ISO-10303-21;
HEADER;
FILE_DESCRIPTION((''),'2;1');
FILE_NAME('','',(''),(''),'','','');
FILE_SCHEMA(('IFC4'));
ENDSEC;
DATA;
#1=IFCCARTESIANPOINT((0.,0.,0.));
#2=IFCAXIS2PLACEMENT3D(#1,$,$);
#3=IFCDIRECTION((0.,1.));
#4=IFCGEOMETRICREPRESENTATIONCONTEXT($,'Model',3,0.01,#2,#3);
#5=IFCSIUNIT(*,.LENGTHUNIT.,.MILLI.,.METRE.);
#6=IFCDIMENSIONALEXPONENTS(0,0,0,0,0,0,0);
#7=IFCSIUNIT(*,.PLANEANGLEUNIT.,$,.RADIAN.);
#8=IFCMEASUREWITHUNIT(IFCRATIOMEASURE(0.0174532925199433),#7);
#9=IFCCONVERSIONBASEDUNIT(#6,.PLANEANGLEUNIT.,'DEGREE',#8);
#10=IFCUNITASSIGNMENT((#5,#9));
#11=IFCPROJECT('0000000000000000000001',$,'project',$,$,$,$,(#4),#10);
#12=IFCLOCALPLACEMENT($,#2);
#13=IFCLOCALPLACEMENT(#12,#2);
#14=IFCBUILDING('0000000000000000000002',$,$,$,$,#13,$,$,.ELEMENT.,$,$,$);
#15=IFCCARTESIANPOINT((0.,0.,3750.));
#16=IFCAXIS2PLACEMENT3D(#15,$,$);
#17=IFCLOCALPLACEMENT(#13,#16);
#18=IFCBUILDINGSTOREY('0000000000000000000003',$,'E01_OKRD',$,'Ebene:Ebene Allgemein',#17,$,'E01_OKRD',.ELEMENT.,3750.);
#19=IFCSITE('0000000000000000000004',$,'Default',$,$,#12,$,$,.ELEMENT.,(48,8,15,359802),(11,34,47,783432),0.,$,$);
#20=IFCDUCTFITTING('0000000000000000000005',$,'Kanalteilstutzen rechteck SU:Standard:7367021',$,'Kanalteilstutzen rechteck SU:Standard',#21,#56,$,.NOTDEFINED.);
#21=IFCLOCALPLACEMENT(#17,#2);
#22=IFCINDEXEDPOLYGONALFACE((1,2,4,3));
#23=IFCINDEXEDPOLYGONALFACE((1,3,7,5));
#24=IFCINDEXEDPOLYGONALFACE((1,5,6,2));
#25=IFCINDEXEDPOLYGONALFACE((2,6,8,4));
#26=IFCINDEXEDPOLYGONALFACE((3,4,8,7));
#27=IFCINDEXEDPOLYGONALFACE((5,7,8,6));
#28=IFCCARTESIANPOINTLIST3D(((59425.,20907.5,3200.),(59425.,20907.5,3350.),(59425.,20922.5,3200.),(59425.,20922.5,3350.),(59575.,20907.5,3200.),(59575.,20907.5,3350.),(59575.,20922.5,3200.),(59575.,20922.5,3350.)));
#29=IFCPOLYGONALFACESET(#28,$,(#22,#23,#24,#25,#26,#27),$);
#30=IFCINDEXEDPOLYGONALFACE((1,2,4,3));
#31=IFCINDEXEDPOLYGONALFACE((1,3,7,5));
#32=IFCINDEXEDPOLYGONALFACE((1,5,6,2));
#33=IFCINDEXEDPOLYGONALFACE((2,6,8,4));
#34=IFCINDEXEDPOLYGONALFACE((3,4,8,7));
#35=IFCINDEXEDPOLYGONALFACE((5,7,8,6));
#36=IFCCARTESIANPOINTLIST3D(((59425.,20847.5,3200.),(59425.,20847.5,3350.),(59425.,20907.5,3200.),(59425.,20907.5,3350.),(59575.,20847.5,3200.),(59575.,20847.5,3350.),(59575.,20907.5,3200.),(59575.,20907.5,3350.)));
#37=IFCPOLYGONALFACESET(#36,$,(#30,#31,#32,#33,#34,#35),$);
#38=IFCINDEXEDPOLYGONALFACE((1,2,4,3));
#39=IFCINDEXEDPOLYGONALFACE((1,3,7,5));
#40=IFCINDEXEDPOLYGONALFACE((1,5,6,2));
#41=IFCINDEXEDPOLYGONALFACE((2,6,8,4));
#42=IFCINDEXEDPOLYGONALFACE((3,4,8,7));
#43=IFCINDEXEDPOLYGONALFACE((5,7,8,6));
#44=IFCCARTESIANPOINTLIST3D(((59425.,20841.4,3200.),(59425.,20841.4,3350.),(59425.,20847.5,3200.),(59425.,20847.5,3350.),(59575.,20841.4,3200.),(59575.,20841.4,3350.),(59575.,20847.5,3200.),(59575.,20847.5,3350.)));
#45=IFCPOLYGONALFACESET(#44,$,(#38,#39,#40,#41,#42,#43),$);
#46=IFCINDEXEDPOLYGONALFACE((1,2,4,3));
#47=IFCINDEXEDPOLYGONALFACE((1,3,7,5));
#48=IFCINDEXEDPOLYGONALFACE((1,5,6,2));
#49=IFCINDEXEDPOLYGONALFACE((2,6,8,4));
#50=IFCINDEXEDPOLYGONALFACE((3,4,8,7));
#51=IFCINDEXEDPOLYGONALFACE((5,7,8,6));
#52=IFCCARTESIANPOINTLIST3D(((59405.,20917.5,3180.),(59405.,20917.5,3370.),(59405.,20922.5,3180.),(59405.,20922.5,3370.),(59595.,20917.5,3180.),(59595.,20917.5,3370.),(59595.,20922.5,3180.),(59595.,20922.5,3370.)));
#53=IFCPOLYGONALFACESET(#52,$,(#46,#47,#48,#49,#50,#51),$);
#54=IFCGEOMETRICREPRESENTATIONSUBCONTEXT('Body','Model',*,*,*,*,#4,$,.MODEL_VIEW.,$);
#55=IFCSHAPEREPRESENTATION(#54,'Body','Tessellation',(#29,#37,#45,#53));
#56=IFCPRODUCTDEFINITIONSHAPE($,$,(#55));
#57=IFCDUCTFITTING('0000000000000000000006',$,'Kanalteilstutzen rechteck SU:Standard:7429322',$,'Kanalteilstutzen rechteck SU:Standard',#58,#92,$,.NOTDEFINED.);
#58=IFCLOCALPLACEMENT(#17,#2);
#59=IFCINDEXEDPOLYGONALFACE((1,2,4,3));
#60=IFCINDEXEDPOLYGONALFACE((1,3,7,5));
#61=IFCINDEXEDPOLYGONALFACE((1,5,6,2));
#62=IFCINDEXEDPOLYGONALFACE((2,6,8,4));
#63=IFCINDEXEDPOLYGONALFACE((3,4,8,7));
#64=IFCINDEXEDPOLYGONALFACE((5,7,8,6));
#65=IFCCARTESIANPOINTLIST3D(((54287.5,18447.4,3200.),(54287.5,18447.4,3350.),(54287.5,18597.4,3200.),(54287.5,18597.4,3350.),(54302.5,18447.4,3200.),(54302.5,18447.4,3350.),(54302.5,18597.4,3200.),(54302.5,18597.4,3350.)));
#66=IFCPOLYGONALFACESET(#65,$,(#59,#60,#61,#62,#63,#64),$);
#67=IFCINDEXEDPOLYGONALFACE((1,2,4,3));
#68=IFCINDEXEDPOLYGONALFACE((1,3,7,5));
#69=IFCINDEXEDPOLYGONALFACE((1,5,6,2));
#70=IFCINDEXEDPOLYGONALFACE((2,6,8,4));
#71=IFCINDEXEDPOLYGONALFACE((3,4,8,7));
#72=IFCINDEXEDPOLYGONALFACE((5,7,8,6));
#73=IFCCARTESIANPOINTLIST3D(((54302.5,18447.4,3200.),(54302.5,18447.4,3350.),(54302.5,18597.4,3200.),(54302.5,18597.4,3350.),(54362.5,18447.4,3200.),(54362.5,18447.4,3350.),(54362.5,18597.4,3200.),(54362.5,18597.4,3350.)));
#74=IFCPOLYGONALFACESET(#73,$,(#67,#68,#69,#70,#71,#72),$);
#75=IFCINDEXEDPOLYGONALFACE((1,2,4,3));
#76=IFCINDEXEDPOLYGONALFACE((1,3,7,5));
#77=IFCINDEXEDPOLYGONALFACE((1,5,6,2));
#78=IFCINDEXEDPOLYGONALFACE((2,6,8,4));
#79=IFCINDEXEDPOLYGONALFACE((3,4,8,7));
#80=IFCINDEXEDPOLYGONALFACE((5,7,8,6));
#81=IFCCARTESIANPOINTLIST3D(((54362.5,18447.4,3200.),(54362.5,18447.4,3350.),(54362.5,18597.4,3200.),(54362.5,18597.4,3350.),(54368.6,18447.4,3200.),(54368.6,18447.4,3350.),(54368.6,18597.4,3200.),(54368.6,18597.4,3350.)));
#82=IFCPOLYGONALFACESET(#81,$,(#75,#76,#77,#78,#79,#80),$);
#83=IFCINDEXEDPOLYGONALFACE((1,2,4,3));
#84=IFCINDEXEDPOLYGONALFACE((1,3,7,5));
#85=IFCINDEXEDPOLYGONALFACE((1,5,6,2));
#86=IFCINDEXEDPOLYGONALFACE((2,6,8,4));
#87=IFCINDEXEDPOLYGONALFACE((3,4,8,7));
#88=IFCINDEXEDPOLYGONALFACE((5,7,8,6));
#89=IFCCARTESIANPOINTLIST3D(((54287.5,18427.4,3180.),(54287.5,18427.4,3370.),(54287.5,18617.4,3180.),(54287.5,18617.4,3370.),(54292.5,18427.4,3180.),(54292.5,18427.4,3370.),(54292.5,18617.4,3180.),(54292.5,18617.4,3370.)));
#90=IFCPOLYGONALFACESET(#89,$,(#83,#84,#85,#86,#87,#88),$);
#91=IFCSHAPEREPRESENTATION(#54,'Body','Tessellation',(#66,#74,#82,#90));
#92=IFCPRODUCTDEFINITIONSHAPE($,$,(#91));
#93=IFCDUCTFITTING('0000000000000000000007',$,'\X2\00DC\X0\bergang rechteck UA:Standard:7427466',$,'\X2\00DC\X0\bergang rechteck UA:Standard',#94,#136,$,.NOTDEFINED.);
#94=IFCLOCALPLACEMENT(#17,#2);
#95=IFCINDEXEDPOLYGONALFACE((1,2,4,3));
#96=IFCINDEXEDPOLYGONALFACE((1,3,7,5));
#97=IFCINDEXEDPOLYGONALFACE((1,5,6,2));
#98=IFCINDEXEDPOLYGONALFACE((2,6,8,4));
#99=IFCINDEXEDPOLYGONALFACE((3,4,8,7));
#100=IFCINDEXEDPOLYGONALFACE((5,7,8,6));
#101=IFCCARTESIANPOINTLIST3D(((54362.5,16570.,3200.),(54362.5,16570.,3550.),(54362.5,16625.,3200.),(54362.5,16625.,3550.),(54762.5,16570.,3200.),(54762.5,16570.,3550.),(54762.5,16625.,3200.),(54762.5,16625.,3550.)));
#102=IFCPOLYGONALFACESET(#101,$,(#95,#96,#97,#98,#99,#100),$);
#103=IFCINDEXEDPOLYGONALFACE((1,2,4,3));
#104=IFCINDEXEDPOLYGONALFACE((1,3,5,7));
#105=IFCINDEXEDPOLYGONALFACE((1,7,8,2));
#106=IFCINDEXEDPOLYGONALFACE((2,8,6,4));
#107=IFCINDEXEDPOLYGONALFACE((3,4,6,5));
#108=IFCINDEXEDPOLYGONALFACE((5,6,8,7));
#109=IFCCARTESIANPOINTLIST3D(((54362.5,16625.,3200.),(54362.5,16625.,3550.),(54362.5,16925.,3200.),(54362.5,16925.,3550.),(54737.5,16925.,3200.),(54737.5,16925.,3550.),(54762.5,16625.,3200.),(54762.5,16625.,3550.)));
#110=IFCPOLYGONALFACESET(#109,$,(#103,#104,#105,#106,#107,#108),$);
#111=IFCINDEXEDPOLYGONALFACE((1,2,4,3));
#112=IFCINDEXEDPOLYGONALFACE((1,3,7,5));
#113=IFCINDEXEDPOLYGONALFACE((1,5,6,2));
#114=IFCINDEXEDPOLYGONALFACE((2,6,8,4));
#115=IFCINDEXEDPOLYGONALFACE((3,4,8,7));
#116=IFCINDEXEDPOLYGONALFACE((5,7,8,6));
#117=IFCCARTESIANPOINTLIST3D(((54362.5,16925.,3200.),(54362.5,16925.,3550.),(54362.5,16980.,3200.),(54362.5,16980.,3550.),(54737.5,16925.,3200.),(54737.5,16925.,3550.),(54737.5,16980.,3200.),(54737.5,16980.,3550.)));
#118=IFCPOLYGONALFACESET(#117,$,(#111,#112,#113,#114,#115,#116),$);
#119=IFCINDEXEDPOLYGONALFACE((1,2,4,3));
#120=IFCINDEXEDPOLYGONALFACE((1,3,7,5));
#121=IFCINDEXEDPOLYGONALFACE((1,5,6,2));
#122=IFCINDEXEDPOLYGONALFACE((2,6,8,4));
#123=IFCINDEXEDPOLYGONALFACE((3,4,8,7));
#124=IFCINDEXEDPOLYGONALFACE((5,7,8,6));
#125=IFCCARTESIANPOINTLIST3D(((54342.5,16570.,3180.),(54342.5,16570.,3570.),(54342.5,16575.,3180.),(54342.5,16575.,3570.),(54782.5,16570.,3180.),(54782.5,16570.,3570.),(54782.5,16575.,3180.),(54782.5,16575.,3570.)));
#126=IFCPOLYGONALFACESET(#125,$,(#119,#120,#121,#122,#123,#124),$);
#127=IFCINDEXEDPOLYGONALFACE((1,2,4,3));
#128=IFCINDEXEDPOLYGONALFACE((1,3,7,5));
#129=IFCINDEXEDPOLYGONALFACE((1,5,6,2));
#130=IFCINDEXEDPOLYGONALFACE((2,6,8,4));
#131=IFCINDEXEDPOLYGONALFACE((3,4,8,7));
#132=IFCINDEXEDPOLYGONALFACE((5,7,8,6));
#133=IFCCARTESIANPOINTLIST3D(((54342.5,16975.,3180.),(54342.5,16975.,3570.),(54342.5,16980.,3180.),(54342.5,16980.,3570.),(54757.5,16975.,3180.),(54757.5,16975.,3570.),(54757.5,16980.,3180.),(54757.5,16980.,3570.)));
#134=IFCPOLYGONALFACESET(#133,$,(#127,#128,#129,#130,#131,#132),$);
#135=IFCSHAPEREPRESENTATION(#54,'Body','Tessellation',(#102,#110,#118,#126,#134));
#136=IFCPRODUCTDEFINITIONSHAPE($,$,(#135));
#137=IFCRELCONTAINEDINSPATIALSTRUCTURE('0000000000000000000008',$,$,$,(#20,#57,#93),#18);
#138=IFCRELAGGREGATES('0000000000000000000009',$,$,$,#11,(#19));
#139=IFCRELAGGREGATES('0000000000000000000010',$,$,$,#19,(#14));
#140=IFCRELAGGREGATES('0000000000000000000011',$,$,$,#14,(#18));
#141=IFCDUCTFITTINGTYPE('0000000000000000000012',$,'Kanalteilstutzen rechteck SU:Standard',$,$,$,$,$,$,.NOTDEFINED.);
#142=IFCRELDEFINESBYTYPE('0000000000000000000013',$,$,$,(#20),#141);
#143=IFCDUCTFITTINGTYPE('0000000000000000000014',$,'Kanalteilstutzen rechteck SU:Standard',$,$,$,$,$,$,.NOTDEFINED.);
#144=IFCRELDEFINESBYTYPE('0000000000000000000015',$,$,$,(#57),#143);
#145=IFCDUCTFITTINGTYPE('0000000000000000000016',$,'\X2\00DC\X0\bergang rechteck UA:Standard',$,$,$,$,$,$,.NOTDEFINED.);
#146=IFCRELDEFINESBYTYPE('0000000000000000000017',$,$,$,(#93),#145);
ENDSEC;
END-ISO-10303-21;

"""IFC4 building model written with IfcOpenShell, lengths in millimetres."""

from ifc_helpers import new_model, entity, si_unit, converted_unit, direction, frame, frame_2d, origin, origin_2d_with_axis, place, context, subcontext, project, spatial, polyline, rectangle, outline, extrude, source, transform, mapped, type_object, type_shapes, element, save


model = new_model("IFC4")

# Units and contexts
model_context = context("Model", 3, precision=0.01, world=origin(), true_north=direction((0.0, 1.0)))
body_context = subcontext(model_context, "Body", "Model", "MODEL_VIEW")
ifc_project = project(units=[si_unit("LENGTHUNIT", "METRE", prefix="MILLI"), converted_unit("PLANEANGLEUNIT", "DEGREE", entity("IfcRatioMeasure", 0.0174532925199433), si_unit("PLANEANGLEUNIT", "RADIAN"), dimensions=[0, 0, 0, 0, 0, 0, 0])], contexts=[model_context])

# Site, building, storey
site_placement = place(None, origin())
site = spatial("IfcSite", under=ifc_project, at=site_placement, Name="Default", CompositionType="ELEMENT", RefLatitude=(48, 8, 15, 359802), RefLongitude=(11, 34, 47, 783432), RefElevation=0.0)
building_placement = place(site_placement, origin())
building = spatial("IfcBuilding", under=site, at=building_placement, CompositionType="ELEMENT")
storey_placement = place(building_placement, frame((0.0, 0.0, 3750.0)))
storey = spatial("IfcBuildingStorey", under=building, at=storey_placement, Name="E01_OKRD", ObjectType="Ebene:Ebene Allgemein", LongName="E01_OKRD", CompositionType="ELEMENT", Elevation=3750.0)

# Duct fittings
duct_fitting_type_1 = type_object("IfcDuctFittingType", Name="Kanalteilstutzen rechteck SU:Standard", PredefinedType="NOTDEFINED")
shared_shape_1 = source(origin(), body_context, "Body", "SweptSolid", [
    extrude(rectangle(XDim=150.0, YDim=15.0, at=origin_2d_with_axis()), frame((67.5, 0.0, -75.0), z_axis=(0.0, 0.0, 1.0), x_axis=(0.0, -1.0, 0.0)), (0.0, 0.0, 1.0), 150.0),
    extrude(rectangle(XDim=150.0, YDim=60.0, at=frame_2d((0.0, 0.0), x_axis=(1.0, 0.0))), frame((30.0, 0.0, -75.0), z_axis=(0.0, 0.0, 1.0), x_axis=(0.0, -1.0, 0.0)), (0.0, 0.0, 1.0), 150.0),
    extrude(rectangle(XDim=150.0, YDim=6.1, at=frame_2d((0.0, 0.0), x_axis=(1.0, 0.0))), frame((-3.0, 0.0, -75.0), z_axis=(0.0, 0.0, 1.0), x_axis=(0.0, -1.0, 0.0)), (0.0, 0.0, 1.0), 150.0),
    extrude(rectangle(XDim=190.0, YDim=5.0, at=origin_2d_with_axis()), frame((72.5, 0.0, -95.0), z_axis=(0.0, 0.0, 1.0), x_axis=(0.0, -1.0, 0.0)), (0.0, 0.0, 1.0), 190.0),
])
type_shapes(duct_fitting_type_1, [shared_shape_1])
duct_fitting_1_placement = place(storey_placement, frame((59500.0, 20847.5, 3275.0), z_axis=(0.0, 0.0, -1.0), x_axis=(0.0, 1.0, 0.0)))
element("IfcDuctFitting", 1, at=duct_fitting_1_placement, inside=storey, type_object=duct_fitting_type_1, Name="Kanalteilstutzen rechteck SU:Standard:7367021", ObjectType="Kanalteilstutzen rechteck SU:Standard", PredefinedType="NOTDEFINED", context=body_context, shape_type="MappedRepresentation", body=[
    mapped(shared_shape_1, transform((0.0, 0.0, 0.0), scale=1.0)),
])
duct_fitting_type_2 = type_object("IfcDuctFittingType", Name="Kanalteilstutzen rechteck SU:Standard", PredefinedType="NOTDEFINED")
shared_shape_2 = source(origin(), body_context, "Body", "SweptSolid", [
    extrude(rectangle(XDim=15.0, YDim=150.0, at=frame_2d((0.0, 0.0), x_axis=(1.0, 0.0))), frame((67.5, 0.0, -75.0)), (0.0, 0.0, 1.0), 150.0),
    extrude(rectangle(XDim=60.0, YDim=150.0, at=frame_2d((0.0, 0.0), x_axis=(1.0, 0.0))), frame((30.0, 0.0, -75.0)), (0.0, 0.0, 1.0), 150.0),
    extrude(rectangle(XDim=6.1, YDim=150.0, at=frame_2d((0.0, 0.0), x_axis=(1.0, 0.0))), frame((-3.0, 0.0, -75.0)), (0.0, 0.0, 1.0), 150.0),
    extrude(rectangle(XDim=5.0, YDim=190.0, at=origin_2d_with_axis()), frame((72.5, 0.0, -95.0)), (0.0, 0.0, 1.0), 190.0),
])
type_shapes(duct_fitting_type_2, [shared_shape_2])
duct_fitting_2_placement = place(storey_placement, frame((54362.5, 18522.4, 3275.0), z_axis=(0.0, 0.0, -1.0), x_axis=(-1.0, 0.0, 0.0)))
element("IfcDuctFitting", 2, at=duct_fitting_2_placement, inside=storey, type_object=duct_fitting_type_2, Name="Kanalteilstutzen rechteck SU:Standard:7429322", ObjectType="Kanalteilstutzen rechteck SU:Standard", PredefinedType="NOTDEFINED", context=body_context, shape_type="MappedRepresentation", body=[
    mapped(shared_shape_2, transform((0.0, 0.0, 0.0), scale=1.0)),
])
duct_fitting_type_3 = type_object("IfcDuctFittingType", Name="Übergang rechteck UA:Standard", PredefinedType="NOTDEFINED")
shared_shape_3 = source(origin(), body_context, "Body", "SweptSolid", [
    extrude(rectangle(XDim=55.0, YDim=400.0, at=frame_2d((0.0, 0.0), x_axis=(1.0, 0.0))), frame((382.5, 12.5, -175.0)), (0.0, 0.0, 1.0), 350.0),
    extrude(outline(polyline([(-150.0, -193.8), (150.0, -193.8), (150.0, 206.2), (-150.0, 181.2), (-150.0, -193.8)])), frame((205.0, 6.2, -175.0)), (0.0, 0.0, 1.0), 350.0),
    extrude(rectangle(XDim=55.0, YDim=375.0, at=frame_2d((0.0, 0.0), x_axis=(1.0, 0.0))), frame((27.5, 0.0, -175.0)), (0.0, 0.0, 1.0), 350.0),
    extrude(rectangle(XDim=5.0, YDim=440.0, at=origin_2d_with_axis()), frame((407.5, 12.5, -195.0)), (0.0, 0.0, 1.0), 390.0),
    extrude(rectangle(XDim=5.0, YDim=415.0, at=frame_2d((0.0, 0.0), x_axis=(1.0, 0.0))), frame((2.5, 0.0, -195.0)), (0.0, 0.0, 1.0), 390.0),
])
type_shapes(duct_fitting_type_3, [shared_shape_3])
duct_fitting_3_placement = place(storey_placement, frame((54550.0, 16980.0, 3375.0), z_axis=(0.0, 0.0, 1.0), x_axis=(0.0, -1.0, 0.0)))
element("IfcDuctFitting", 3, at=duct_fitting_3_placement, inside=storey, type_object=duct_fitting_type_3, Name="Übergang rechteck UA:Standard:7427466", ObjectType="Übergang rechteck UA:Standard", PredefinedType="NOTDEFINED", context=body_context, shape_type="MappedRepresentation", body=[
    mapped(shared_shape_3, transform((0.0, 0.0, 0.0), scale=1.0)),
])

save(model, "model.ifc")
